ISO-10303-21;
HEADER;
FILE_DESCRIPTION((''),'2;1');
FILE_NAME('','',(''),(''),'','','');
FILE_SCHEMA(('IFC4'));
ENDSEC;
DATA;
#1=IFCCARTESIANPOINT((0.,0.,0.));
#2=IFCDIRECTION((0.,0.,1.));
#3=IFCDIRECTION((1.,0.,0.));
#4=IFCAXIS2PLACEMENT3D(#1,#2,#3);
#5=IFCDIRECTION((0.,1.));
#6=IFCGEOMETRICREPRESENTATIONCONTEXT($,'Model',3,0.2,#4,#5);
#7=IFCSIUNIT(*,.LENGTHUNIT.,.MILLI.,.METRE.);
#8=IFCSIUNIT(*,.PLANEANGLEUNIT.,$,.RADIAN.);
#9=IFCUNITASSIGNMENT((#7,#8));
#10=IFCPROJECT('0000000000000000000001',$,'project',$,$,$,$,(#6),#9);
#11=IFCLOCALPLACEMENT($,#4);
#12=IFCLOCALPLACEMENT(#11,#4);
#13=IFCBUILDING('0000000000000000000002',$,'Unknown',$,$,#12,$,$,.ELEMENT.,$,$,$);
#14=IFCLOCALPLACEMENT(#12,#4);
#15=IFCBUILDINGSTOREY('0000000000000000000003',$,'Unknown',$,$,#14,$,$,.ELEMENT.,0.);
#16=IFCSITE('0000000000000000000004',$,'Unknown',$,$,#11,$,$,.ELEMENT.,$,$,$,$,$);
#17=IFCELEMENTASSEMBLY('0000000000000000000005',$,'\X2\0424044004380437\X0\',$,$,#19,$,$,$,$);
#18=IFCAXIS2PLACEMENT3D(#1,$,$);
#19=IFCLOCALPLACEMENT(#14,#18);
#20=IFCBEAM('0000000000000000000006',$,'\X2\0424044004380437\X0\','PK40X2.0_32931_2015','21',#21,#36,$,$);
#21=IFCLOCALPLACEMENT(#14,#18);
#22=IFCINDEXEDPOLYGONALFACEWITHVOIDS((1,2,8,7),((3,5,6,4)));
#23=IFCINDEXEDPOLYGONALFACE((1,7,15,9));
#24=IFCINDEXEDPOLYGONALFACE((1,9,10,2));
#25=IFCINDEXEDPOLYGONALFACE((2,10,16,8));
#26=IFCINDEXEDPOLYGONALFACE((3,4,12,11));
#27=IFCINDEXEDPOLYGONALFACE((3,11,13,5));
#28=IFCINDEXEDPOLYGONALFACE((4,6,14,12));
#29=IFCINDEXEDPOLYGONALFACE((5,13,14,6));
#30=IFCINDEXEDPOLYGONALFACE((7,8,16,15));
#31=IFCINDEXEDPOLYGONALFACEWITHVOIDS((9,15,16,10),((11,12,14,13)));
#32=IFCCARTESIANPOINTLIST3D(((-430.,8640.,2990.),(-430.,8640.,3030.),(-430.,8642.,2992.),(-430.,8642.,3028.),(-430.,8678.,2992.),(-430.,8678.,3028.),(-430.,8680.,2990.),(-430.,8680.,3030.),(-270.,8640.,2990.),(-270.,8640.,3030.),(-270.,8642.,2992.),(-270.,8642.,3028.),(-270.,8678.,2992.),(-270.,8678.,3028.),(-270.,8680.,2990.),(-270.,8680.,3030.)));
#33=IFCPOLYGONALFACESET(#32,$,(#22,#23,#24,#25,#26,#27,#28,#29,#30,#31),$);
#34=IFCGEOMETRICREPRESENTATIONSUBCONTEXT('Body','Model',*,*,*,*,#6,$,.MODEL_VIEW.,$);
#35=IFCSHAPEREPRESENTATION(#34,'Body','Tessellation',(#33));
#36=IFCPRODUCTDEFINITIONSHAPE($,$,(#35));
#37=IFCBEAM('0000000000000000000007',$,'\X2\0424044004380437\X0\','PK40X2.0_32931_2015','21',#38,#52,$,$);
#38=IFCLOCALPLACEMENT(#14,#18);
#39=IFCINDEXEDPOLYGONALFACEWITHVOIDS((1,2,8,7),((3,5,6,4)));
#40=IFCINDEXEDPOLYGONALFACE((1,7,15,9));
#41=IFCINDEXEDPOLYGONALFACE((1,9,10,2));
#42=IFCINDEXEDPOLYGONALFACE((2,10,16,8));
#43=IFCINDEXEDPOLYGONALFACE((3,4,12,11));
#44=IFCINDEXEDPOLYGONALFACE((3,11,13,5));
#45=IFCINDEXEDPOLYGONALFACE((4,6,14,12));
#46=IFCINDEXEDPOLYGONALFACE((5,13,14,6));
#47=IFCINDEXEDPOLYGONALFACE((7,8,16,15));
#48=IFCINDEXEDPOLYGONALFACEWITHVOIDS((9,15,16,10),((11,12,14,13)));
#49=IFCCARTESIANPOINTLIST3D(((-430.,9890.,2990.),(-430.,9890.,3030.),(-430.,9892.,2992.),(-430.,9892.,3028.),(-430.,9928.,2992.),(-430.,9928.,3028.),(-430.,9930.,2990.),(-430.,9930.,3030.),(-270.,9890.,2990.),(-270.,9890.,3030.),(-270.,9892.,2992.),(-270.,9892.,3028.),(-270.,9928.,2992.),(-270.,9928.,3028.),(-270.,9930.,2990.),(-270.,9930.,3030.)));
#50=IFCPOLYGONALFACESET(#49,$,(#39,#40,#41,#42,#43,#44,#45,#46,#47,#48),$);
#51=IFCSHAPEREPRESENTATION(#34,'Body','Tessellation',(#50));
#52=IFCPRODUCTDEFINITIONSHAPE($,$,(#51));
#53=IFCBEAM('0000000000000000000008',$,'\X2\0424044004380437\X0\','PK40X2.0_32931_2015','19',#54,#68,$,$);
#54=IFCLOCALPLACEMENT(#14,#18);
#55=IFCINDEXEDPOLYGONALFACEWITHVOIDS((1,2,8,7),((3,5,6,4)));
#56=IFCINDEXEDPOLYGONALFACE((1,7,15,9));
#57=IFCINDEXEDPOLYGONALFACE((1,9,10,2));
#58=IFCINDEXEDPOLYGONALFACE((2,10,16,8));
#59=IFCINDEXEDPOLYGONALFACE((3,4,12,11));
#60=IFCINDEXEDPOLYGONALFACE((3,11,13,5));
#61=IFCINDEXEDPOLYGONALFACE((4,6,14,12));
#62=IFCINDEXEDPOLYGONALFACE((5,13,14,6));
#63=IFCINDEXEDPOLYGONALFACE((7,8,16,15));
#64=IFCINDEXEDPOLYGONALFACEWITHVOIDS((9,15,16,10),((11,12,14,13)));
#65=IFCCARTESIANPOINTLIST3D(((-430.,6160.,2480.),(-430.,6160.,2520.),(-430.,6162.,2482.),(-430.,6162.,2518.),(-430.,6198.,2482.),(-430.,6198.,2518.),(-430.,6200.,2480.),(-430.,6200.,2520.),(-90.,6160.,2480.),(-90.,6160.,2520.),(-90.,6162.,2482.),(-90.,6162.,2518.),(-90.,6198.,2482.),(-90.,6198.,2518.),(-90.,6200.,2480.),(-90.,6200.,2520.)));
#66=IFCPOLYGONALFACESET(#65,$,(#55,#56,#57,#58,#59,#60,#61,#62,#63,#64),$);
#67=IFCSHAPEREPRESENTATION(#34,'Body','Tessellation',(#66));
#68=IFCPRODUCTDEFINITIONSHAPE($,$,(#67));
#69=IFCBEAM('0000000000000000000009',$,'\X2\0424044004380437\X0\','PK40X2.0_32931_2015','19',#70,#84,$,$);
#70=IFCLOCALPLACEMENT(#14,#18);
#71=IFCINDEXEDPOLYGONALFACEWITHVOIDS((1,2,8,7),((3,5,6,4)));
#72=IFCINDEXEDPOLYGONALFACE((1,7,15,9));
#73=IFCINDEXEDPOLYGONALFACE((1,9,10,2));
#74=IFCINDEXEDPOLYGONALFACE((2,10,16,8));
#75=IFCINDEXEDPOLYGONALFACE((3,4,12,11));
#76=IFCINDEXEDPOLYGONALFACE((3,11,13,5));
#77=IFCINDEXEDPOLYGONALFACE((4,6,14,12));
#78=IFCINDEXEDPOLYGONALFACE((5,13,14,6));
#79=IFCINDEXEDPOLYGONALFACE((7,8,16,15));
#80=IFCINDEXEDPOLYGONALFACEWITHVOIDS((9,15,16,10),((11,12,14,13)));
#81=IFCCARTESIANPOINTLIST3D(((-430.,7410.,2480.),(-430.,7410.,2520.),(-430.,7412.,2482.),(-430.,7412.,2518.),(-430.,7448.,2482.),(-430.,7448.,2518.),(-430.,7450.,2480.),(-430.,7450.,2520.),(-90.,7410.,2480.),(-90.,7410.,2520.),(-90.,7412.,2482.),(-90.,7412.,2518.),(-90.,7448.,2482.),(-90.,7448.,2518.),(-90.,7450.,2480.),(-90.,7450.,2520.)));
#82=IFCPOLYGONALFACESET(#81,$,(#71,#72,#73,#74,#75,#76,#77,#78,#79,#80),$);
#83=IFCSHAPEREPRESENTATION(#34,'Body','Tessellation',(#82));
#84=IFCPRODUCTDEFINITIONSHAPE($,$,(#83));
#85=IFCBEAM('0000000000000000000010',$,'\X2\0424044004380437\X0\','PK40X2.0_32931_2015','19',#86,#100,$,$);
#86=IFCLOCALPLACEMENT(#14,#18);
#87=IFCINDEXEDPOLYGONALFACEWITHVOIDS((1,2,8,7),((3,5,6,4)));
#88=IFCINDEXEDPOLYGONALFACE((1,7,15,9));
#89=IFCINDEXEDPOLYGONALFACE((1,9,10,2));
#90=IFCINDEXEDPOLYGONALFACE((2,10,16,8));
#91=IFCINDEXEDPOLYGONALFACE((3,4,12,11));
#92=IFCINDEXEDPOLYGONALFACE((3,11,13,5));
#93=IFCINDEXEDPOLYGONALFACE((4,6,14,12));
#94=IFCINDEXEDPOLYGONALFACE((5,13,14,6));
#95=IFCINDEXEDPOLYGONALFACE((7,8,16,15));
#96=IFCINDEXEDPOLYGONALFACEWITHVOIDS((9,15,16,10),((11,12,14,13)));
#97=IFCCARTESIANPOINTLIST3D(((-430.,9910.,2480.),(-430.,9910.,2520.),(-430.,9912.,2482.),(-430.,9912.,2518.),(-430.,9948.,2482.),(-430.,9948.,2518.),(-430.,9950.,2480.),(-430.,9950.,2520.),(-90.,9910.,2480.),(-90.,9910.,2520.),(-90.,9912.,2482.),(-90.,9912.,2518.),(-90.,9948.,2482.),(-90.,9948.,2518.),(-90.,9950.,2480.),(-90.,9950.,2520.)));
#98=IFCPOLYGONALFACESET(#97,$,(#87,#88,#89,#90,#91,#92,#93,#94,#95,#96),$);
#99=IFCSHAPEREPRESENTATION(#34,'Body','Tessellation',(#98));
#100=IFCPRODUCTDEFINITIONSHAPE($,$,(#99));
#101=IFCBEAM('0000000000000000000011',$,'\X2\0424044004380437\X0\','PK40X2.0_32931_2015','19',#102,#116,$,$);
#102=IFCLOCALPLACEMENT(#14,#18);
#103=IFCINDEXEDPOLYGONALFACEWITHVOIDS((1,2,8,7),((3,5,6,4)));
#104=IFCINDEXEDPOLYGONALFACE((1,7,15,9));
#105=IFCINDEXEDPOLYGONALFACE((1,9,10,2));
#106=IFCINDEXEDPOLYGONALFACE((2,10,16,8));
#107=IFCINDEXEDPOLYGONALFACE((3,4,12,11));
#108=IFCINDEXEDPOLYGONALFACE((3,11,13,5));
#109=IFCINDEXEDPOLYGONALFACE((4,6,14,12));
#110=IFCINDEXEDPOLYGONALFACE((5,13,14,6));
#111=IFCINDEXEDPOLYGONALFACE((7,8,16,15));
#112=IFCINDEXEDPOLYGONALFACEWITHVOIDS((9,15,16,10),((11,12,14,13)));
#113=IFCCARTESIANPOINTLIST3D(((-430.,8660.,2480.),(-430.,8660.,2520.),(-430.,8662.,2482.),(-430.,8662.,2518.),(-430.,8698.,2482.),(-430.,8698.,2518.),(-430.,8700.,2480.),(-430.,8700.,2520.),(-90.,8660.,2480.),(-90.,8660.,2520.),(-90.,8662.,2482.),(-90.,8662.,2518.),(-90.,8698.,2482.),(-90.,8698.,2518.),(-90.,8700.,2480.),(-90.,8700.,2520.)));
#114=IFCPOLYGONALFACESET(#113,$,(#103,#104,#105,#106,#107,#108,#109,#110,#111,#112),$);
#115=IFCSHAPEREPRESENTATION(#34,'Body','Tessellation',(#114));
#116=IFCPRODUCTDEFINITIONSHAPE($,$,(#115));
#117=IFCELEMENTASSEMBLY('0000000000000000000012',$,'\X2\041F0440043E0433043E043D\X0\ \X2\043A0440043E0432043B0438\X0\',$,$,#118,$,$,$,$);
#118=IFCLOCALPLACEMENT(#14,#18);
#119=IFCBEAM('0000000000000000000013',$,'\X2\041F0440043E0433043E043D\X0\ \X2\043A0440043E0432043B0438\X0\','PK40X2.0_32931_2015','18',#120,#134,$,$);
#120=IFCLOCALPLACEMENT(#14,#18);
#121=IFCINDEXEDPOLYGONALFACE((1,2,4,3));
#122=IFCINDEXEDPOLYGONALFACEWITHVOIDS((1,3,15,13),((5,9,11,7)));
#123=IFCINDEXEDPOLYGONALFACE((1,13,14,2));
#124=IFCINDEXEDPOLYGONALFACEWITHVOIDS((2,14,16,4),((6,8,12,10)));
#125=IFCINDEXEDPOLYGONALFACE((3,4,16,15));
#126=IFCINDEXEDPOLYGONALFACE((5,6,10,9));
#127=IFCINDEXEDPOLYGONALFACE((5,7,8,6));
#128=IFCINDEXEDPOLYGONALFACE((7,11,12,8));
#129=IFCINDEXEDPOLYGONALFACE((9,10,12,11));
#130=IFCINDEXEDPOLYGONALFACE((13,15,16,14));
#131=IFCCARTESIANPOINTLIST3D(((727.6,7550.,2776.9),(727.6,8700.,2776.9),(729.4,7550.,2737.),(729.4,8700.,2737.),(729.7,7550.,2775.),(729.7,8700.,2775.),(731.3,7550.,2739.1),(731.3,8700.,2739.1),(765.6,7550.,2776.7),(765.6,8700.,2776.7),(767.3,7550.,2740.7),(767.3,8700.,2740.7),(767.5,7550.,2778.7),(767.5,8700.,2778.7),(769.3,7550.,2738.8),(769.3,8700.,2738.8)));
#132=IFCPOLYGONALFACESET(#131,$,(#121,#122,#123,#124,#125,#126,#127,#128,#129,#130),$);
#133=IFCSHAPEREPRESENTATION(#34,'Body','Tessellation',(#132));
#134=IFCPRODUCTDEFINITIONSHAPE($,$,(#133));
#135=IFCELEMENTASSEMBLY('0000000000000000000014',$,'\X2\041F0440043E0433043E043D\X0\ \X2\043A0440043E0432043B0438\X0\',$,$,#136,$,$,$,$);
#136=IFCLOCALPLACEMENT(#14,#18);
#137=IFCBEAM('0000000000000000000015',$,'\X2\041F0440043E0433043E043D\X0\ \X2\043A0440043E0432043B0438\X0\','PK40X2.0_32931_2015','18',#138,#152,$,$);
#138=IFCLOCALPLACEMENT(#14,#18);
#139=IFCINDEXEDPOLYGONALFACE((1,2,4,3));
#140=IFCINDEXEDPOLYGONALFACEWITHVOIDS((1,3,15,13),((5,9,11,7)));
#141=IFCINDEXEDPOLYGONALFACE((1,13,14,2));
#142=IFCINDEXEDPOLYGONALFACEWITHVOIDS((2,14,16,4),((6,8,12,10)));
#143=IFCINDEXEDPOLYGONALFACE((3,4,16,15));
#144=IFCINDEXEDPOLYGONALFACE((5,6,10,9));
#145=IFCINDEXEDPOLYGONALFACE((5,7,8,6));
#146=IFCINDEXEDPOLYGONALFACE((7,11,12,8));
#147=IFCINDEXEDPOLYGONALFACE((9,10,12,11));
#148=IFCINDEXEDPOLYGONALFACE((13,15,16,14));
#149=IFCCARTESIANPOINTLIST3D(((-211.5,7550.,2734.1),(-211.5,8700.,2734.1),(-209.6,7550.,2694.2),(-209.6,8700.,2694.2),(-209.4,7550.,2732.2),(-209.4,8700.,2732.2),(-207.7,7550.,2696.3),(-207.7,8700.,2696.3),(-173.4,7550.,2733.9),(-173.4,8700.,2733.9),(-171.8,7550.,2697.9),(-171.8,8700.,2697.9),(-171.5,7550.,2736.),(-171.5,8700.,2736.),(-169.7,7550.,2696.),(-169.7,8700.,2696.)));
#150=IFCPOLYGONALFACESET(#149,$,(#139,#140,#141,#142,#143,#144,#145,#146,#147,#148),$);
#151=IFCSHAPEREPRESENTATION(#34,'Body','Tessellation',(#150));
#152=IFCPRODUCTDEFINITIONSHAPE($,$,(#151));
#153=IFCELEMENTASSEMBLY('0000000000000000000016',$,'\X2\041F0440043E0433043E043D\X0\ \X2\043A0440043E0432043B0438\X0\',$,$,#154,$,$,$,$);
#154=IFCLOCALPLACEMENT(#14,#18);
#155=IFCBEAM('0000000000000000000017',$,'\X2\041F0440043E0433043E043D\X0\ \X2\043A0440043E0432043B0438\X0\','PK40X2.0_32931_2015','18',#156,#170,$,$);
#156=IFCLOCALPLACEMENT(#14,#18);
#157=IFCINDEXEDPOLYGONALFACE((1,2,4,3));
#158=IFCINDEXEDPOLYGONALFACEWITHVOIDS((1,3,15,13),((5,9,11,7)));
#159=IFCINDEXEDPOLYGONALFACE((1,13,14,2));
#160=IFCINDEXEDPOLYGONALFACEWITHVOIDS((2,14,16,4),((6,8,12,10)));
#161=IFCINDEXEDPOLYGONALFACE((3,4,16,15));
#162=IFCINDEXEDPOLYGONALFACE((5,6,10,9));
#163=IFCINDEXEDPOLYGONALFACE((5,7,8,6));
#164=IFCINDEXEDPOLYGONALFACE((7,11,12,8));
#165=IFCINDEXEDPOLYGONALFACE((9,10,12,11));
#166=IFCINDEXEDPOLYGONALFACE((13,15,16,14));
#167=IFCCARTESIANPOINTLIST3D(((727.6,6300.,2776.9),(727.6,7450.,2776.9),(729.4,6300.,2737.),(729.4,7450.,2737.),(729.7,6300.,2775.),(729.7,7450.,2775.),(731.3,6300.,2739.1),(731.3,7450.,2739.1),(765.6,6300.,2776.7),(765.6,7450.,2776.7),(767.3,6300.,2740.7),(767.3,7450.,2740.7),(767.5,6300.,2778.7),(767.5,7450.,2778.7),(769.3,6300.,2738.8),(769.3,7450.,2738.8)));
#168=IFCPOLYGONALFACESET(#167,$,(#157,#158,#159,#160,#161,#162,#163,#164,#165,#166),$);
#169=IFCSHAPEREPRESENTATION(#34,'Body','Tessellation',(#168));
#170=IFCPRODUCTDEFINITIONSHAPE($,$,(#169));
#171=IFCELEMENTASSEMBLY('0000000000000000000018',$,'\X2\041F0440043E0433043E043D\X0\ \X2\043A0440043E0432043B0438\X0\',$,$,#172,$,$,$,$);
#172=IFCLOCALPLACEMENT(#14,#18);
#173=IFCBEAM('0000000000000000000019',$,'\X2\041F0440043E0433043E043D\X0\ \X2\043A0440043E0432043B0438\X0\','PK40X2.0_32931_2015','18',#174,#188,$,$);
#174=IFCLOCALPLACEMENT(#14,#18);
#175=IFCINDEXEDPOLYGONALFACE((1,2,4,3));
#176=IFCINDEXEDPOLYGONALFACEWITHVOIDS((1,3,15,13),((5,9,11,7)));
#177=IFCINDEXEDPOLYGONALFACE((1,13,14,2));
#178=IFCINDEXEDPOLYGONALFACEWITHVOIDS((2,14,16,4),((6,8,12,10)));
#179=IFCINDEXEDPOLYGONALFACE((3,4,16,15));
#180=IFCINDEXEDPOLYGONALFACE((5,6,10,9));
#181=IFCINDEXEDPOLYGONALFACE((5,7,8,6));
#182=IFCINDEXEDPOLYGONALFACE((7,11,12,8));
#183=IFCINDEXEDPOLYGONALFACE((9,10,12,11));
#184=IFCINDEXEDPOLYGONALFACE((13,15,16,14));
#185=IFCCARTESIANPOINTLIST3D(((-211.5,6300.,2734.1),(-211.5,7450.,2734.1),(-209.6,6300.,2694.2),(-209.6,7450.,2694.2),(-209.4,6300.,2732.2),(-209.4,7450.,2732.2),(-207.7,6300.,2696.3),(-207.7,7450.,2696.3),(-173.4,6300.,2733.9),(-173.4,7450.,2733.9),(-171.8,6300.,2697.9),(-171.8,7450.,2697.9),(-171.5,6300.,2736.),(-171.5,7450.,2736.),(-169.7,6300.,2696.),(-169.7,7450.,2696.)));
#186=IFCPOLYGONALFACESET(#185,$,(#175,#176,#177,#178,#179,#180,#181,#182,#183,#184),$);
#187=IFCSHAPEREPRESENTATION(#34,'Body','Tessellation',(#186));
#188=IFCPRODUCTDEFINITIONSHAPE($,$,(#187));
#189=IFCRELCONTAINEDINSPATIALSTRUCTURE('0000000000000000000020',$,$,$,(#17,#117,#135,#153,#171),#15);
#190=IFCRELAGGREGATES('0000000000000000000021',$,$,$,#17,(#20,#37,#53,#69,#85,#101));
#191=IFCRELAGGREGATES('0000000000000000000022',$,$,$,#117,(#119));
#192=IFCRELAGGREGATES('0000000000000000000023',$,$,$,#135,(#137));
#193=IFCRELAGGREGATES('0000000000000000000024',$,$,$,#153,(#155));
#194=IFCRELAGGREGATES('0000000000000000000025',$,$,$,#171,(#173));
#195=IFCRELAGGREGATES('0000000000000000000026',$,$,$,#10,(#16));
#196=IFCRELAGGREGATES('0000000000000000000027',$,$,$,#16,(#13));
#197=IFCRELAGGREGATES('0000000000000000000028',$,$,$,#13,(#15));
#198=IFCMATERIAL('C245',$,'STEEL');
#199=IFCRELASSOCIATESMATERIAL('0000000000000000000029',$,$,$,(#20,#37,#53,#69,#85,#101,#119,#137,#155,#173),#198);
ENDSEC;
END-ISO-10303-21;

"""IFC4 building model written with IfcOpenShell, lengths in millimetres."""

from ifc_helpers import new_model, si_unit, direction, frame, origin_with_axes, place, context, subcontext, project, spatial, line, indexed_curve, outline, extrude, material, element, aggregate, save


model = new_model("IFC4")

# Units and contexts
model_context = context("Model", 3, precision=0.2, world=origin_with_axes(), true_north=direction((0.0, 1.0)))
body_context = subcontext(model_context, "Body", "Model", "MODEL_VIEW")
ifc_project = project(units=[si_unit("LENGTHUNIT", "METRE", prefix="MILLI"), si_unit("PLANEANGLEUNIT", "RADIAN")], contexts=[model_context])

# Site, building, storey
site_placement = place(None, origin_with_axes())
site = spatial("IfcSite", under=ifc_project, at=site_placement, Name="Unknown", CompositionType="ELEMENT")
building_placement = place(site_placement, origin_with_axes())
building = spatial("IfcBuilding", under=site, at=building_placement, Name="Unknown", CompositionType="ELEMENT")
storey_placement = place(building_placement, origin_with_axes())
storey = spatial("IfcBuildingStorey", under=building, at=storey_placement, Name="Unknown", CompositionType="ELEMENT", Elevation=0.0)

# Shared definitions
ifc_material = material(Name="C245", Category="STEEL")

# Element assembly
assembly_1_placement = place(storey_placement, frame((-450.0, -500.0, 3010.0), z_axis=(1.0, 0.0, 0.0), x_axis=(0.0, 1.0, 0.0)))
assembly_1 = element("IfcElementAssembly", 1, at=assembly_1_placement, inside=storey, Name="Фриз")

# Beams
beam_1_placement = place(assembly_1_placement, frame((9160.0, 0.0, 20.0), z_axis=(-1.0, 0.0, 0.0), x_axis=(0.0, 0.0, 1.0)))
beam_1 = element("IfcBeam", 2, at=beam_1_placement, material=ifc_material, Name="Фриз", Description="PK40X2.0_32931_2015", ObjectType="21", context=body_context, shape_type="SolidModel", body=[
    extrude(outline(indexed_curve([(-20.0, -20.0), (20.0, -20.0), (20.0, 20.0), (-20.0, 20.0)], segments=[line(1, 2, 3, 4, 1)]), holes=[indexed_curve([(-18.0, -18.0), (-18.0, 18.0), (18.0, 18.0), (18.0, -18.0)], segments=[line(1, 2, 3, 4, 1)])]), frame((0.0, 0.0, 0.0), z_axis=(-1.0, 0.0, 0.0), x_axis=(0.0, 0.0, 1.0)), (0.0, 0.0, -1.0), 160.0),
])
beam_2_placement = place(assembly_1_placement, frame((10410.0, 0.0, 20.0), z_axis=(-1.0, 0.0, 0.0), x_axis=(0.0, 0.0, 1.0)))
beam_2 = element("IfcBeam", 3, at=beam_2_placement, material=ifc_material, Name="Фриз", Description="PK40X2.0_32931_2015", ObjectType="21", context=body_context, shape_type="SolidModel", body=[
    extrude(outline(indexed_curve([(-20.0, -20.0), (20.0, -20.0), (20.0, 20.0), (-20.0, 20.0)], segments=[line(1, 2, 3, 4, 1)]), holes=[indexed_curve([(-18.0, -18.0), (-18.0, 18.0), (18.0, 18.0), (18.0, -18.0)], segments=[line(1, 2, 3, 4, 1)])]), frame((0.0, 0.0, 0.0), z_axis=(-1.0, 0.0, 0.0), x_axis=(0.0, 0.0, 1.0)), (0.0, 0.0, -1.0), 160.0),
])
beam_3_placement = place(assembly_1_placement, frame((6680.0, -510.0, 20.0), z_axis=(-1.0, 0.0, 0.0), x_axis=(0.0, 0.0, 1.0)))
beam_3 = element("IfcBeam", 4, at=beam_3_placement, material=ifc_material, Name="Фриз", Description="PK40X2.0_32931_2015", ObjectType="19", context=body_context, shape_type="SolidModel", body=[
    extrude(outline(indexed_curve([(-20.0, -20.0), (20.0, -20.0), (20.0, 20.0), (-20.0, 20.0)], segments=[line(1, 2, 3, 4, 1)]), holes=[indexed_curve([(-18.0, -18.0), (-18.0, 18.0), (18.0, 18.0), (18.0, -18.0)], segments=[line(1, 2, 3, 4, 1)])]), frame((0.0, 0.0, 0.0), z_axis=(-1.0, 0.0, 0.0), x_axis=(0.0, 0.0, 1.0)), (0.0, 0.0, -1.0), 340.0),
])
beam_4_placement = place(assembly_1_placement, frame((7930.0, -510.0, 20.0), z_axis=(-1.0, 0.0, 0.0), x_axis=(0.0, 0.0, 1.0)))
beam_4 = element("IfcBeam", 5, at=beam_4_placement, material=ifc_material, Name="Фриз", Description="PK40X2.0_32931_2015", ObjectType="19", context=body_context, shape_type="SolidModel", body=[
    extrude(outline(indexed_curve([(-20.0, -20.0), (20.0, -20.0), (20.0, 20.0), (-20.0, 20.0)], segments=[line(1, 2, 3, 4, 1)]), holes=[indexed_curve([(-18.0, -18.0), (-18.0, 18.0), (18.0, 18.0), (18.0, -18.0)], segments=[line(1, 2, 3, 4, 1)])]), frame((0.0, 0.0, 0.0), z_axis=(-1.0, 0.0, 0.0), x_axis=(0.0, 0.0, 1.0)), (0.0, 0.0, -1.0), 340.0),
])
beam_5_placement = place(assembly_1_placement, frame((10430.0, -510.0, 20.0), z_axis=(-1.0, 0.0, 0.0), x_axis=(0.0, 0.0, 1.0)))
beam_5 = element("IfcBeam", 6, at=beam_5_placement, material=ifc_material, Name="Фриз", Description="PK40X2.0_32931_2015", ObjectType="19", context=body_context, shape_type="SolidModel", body=[
    extrude(outline(indexed_curve([(-20.0, -20.0), (20.0, -20.0), (20.0, 20.0), (-20.0, 20.0)], segments=[line(1, 2, 3, 4, 1)]), holes=[indexed_curve([(-18.0, -18.0), (-18.0, 18.0), (18.0, 18.0), (18.0, -18.0)], segments=[line(1, 2, 3, 4, 1)])]), frame((0.0, 0.0, 0.0), z_axis=(-1.0, 0.0, 0.0), x_axis=(0.0, 0.0, 1.0)), (0.0, 0.0, -1.0), 340.0),
])
beam_6_placement = place(assembly_1_placement, frame((9180.0, -510.0, 20.0), z_axis=(-1.0, 0.0, 0.0), x_axis=(0.0, 0.0, 1.0)))
beam_6 = element("IfcBeam", 7, at=beam_6_placement, material=ifc_material, Name="Фриз", Description="PK40X2.0_32931_2015", ObjectType="19", context=body_context, shape_type="SolidModel", body=[
    extrude(outline(indexed_curve([(-20.0, -20.0), (20.0, -20.0), (20.0, 20.0), (-20.0, 20.0)], segments=[line(1, 2, 3, 4, 1)]), holes=[indexed_curve([(-18.0, -18.0), (-18.0, 18.0), (18.0, 18.0), (18.0, -18.0)], segments=[line(1, 2, 3, 4, 1)])]), frame((0.0, 0.0, 0.0), z_axis=(-1.0, 0.0, 0.0), x_axis=(0.0, 0.0, 1.0)), (0.0, 0.0, -1.0), 340.0),
])
aggregate(assembly_1, [beam_1, beam_2, beam_3, beam_4, beam_5, beam_6])

# Element assemblies, beams
assembly_2_placement = place(storey_placement, frame((748.5, 8700.0, 2757.9), z_axis=(-0.998964, 0.0, -0.045508), x_axis=(0.0, -1.0, 0.0)))
assembly_2 = element("IfcElementAssembly", 8, at=assembly_2_placement, inside=storey, Name="Прогон кровли")
beam_7_placement = place(assembly_2_placement, origin_with_axes())
beam_7 = element("IfcBeam", 9, at=beam_7_placement, material=ifc_material, Name="Прогон кровли", Description="PK40X2.0_32931_2015", ObjectType="18", context=body_context, shape_type="SolidModel", body=[
    extrude(outline(indexed_curve([(-20.0, -20.0), (20.0, -20.0), (20.0, 20.0), (-20.0, 20.0)], segments=[line(1, 2, 3, 4, 1)]), holes=[indexed_curve([(-18.0, -18.0), (-18.0, 18.0), (18.0, 18.0), (18.0, -18.0)], segments=[line(1, 2, 3, 4, 1)])]), frame((0.0, 0.0, 0.0), z_axis=(-1.0, 0.0, 0.0), x_axis=(0.0, 0.0, 1.0)), (0.0, 0.0, -1.0), 1150.0),
])
aggregate(assembly_2, [beam_7])
assembly_3_placement = place(storey_placement, frame((-190.6, 8700.0, 2715.1), z_axis=(-0.998964, 0.0, -0.045508), x_axis=(0.0, -1.0, 0.0)))
assembly_3 = element("IfcElementAssembly", 10, at=assembly_3_placement, inside=storey, Name="Прогон кровли")
beam_8_placement = place(assembly_3_placement, origin_with_axes())
beam_8 = element("IfcBeam", 11, at=beam_8_placement, material=ifc_material, Name="Прогон кровли", Description="PK40X2.0_32931_2015", ObjectType="18", context=body_context, shape_type="SolidModel", body=[
    extrude(outline(indexed_curve([(-20.0, -20.0), (20.0, -20.0), (20.0, 20.0), (-20.0, 20.0)], segments=[line(1, 2, 3, 4, 1)]), holes=[indexed_curve([(-18.0, -18.0), (-18.0, 18.0), (18.0, 18.0), (18.0, -18.0)], segments=[line(1, 2, 3, 4, 1)])]), frame((0.0, 0.0, 0.0), z_axis=(-1.0, 0.0, 0.0), x_axis=(0.0, 0.0, 1.0)), (0.0, 0.0, -1.0), 1150.0),
])
aggregate(assembly_3, [beam_8])
assembly_4_placement = place(storey_placement, frame((748.5, 7450.0, 2757.9), z_axis=(-0.998964, 0.0, -0.045508), x_axis=(0.0, -1.0, 0.0)))
assembly_4 = element("IfcElementAssembly", 12, at=assembly_4_placement, inside=storey, Name="Прогон кровли")
beam_9_placement = place(assembly_4_placement, origin_with_axes())
beam_9 = element("IfcBeam", 13, at=beam_9_placement, material=ifc_material, Name="Прогон кровли", Description="PK40X2.0_32931_2015", ObjectType="18", context=body_context, shape_type="SolidModel", body=[
    extrude(outline(indexed_curve([(-20.0, -20.0), (20.0, -20.0), (20.0, 20.0), (-20.0, 20.0)], segments=[line(1, 2, 3, 4, 1)]), holes=[indexed_curve([(-18.0, -18.0), (-18.0, 18.0), (18.0, 18.0), (18.0, -18.0)], segments=[line(1, 2, 3, 4, 1)])]), frame((0.0, 0.0, 0.0), z_axis=(-1.0, 0.0, 0.0), x_axis=(0.0, 0.0, 1.0)), (0.0, 0.0, -1.0), 1150.0),
])
aggregate(assembly_4, [beam_9])
assembly_5_placement = place(storey_placement, frame((-190.6, 7450.0, 2715.1), z_axis=(-0.998964, 0.0, -0.045508), x_axis=(0.0, -1.0, 0.0)))
assembly_5 = element("IfcElementAssembly", 14, at=assembly_5_placement, inside=storey, Name="Прогон кровли")
beam_10_placement = place(assembly_5_placement, origin_with_axes())
beam_10 = element("IfcBeam", 15, at=beam_10_placement, material=ifc_material, Name="Прогон кровли", Description="PK40X2.0_32931_2015", ObjectType="18", context=body_context, shape_type="SolidModel", body=[
    extrude(outline(indexed_curve([(-20.0, -20.0), (20.0, -20.0), (20.0, 20.0), (-20.0, 20.0)], segments=[line(1, 2, 3, 4, 1)]), holes=[indexed_curve([(-18.0, -18.0), (-18.0, 18.0), (18.0, 18.0), (18.0, -18.0)], segments=[line(1, 2, 3, 4, 1)])]), frame((0.0, 0.0, 0.0), z_axis=(-1.0, 0.0, 0.0), x_axis=(0.0, 0.0, 1.0)), (0.0, 0.0, -1.0), 1150.0),
])
aggregate(assembly_5, [beam_10])

save(model, "model.ifc")
